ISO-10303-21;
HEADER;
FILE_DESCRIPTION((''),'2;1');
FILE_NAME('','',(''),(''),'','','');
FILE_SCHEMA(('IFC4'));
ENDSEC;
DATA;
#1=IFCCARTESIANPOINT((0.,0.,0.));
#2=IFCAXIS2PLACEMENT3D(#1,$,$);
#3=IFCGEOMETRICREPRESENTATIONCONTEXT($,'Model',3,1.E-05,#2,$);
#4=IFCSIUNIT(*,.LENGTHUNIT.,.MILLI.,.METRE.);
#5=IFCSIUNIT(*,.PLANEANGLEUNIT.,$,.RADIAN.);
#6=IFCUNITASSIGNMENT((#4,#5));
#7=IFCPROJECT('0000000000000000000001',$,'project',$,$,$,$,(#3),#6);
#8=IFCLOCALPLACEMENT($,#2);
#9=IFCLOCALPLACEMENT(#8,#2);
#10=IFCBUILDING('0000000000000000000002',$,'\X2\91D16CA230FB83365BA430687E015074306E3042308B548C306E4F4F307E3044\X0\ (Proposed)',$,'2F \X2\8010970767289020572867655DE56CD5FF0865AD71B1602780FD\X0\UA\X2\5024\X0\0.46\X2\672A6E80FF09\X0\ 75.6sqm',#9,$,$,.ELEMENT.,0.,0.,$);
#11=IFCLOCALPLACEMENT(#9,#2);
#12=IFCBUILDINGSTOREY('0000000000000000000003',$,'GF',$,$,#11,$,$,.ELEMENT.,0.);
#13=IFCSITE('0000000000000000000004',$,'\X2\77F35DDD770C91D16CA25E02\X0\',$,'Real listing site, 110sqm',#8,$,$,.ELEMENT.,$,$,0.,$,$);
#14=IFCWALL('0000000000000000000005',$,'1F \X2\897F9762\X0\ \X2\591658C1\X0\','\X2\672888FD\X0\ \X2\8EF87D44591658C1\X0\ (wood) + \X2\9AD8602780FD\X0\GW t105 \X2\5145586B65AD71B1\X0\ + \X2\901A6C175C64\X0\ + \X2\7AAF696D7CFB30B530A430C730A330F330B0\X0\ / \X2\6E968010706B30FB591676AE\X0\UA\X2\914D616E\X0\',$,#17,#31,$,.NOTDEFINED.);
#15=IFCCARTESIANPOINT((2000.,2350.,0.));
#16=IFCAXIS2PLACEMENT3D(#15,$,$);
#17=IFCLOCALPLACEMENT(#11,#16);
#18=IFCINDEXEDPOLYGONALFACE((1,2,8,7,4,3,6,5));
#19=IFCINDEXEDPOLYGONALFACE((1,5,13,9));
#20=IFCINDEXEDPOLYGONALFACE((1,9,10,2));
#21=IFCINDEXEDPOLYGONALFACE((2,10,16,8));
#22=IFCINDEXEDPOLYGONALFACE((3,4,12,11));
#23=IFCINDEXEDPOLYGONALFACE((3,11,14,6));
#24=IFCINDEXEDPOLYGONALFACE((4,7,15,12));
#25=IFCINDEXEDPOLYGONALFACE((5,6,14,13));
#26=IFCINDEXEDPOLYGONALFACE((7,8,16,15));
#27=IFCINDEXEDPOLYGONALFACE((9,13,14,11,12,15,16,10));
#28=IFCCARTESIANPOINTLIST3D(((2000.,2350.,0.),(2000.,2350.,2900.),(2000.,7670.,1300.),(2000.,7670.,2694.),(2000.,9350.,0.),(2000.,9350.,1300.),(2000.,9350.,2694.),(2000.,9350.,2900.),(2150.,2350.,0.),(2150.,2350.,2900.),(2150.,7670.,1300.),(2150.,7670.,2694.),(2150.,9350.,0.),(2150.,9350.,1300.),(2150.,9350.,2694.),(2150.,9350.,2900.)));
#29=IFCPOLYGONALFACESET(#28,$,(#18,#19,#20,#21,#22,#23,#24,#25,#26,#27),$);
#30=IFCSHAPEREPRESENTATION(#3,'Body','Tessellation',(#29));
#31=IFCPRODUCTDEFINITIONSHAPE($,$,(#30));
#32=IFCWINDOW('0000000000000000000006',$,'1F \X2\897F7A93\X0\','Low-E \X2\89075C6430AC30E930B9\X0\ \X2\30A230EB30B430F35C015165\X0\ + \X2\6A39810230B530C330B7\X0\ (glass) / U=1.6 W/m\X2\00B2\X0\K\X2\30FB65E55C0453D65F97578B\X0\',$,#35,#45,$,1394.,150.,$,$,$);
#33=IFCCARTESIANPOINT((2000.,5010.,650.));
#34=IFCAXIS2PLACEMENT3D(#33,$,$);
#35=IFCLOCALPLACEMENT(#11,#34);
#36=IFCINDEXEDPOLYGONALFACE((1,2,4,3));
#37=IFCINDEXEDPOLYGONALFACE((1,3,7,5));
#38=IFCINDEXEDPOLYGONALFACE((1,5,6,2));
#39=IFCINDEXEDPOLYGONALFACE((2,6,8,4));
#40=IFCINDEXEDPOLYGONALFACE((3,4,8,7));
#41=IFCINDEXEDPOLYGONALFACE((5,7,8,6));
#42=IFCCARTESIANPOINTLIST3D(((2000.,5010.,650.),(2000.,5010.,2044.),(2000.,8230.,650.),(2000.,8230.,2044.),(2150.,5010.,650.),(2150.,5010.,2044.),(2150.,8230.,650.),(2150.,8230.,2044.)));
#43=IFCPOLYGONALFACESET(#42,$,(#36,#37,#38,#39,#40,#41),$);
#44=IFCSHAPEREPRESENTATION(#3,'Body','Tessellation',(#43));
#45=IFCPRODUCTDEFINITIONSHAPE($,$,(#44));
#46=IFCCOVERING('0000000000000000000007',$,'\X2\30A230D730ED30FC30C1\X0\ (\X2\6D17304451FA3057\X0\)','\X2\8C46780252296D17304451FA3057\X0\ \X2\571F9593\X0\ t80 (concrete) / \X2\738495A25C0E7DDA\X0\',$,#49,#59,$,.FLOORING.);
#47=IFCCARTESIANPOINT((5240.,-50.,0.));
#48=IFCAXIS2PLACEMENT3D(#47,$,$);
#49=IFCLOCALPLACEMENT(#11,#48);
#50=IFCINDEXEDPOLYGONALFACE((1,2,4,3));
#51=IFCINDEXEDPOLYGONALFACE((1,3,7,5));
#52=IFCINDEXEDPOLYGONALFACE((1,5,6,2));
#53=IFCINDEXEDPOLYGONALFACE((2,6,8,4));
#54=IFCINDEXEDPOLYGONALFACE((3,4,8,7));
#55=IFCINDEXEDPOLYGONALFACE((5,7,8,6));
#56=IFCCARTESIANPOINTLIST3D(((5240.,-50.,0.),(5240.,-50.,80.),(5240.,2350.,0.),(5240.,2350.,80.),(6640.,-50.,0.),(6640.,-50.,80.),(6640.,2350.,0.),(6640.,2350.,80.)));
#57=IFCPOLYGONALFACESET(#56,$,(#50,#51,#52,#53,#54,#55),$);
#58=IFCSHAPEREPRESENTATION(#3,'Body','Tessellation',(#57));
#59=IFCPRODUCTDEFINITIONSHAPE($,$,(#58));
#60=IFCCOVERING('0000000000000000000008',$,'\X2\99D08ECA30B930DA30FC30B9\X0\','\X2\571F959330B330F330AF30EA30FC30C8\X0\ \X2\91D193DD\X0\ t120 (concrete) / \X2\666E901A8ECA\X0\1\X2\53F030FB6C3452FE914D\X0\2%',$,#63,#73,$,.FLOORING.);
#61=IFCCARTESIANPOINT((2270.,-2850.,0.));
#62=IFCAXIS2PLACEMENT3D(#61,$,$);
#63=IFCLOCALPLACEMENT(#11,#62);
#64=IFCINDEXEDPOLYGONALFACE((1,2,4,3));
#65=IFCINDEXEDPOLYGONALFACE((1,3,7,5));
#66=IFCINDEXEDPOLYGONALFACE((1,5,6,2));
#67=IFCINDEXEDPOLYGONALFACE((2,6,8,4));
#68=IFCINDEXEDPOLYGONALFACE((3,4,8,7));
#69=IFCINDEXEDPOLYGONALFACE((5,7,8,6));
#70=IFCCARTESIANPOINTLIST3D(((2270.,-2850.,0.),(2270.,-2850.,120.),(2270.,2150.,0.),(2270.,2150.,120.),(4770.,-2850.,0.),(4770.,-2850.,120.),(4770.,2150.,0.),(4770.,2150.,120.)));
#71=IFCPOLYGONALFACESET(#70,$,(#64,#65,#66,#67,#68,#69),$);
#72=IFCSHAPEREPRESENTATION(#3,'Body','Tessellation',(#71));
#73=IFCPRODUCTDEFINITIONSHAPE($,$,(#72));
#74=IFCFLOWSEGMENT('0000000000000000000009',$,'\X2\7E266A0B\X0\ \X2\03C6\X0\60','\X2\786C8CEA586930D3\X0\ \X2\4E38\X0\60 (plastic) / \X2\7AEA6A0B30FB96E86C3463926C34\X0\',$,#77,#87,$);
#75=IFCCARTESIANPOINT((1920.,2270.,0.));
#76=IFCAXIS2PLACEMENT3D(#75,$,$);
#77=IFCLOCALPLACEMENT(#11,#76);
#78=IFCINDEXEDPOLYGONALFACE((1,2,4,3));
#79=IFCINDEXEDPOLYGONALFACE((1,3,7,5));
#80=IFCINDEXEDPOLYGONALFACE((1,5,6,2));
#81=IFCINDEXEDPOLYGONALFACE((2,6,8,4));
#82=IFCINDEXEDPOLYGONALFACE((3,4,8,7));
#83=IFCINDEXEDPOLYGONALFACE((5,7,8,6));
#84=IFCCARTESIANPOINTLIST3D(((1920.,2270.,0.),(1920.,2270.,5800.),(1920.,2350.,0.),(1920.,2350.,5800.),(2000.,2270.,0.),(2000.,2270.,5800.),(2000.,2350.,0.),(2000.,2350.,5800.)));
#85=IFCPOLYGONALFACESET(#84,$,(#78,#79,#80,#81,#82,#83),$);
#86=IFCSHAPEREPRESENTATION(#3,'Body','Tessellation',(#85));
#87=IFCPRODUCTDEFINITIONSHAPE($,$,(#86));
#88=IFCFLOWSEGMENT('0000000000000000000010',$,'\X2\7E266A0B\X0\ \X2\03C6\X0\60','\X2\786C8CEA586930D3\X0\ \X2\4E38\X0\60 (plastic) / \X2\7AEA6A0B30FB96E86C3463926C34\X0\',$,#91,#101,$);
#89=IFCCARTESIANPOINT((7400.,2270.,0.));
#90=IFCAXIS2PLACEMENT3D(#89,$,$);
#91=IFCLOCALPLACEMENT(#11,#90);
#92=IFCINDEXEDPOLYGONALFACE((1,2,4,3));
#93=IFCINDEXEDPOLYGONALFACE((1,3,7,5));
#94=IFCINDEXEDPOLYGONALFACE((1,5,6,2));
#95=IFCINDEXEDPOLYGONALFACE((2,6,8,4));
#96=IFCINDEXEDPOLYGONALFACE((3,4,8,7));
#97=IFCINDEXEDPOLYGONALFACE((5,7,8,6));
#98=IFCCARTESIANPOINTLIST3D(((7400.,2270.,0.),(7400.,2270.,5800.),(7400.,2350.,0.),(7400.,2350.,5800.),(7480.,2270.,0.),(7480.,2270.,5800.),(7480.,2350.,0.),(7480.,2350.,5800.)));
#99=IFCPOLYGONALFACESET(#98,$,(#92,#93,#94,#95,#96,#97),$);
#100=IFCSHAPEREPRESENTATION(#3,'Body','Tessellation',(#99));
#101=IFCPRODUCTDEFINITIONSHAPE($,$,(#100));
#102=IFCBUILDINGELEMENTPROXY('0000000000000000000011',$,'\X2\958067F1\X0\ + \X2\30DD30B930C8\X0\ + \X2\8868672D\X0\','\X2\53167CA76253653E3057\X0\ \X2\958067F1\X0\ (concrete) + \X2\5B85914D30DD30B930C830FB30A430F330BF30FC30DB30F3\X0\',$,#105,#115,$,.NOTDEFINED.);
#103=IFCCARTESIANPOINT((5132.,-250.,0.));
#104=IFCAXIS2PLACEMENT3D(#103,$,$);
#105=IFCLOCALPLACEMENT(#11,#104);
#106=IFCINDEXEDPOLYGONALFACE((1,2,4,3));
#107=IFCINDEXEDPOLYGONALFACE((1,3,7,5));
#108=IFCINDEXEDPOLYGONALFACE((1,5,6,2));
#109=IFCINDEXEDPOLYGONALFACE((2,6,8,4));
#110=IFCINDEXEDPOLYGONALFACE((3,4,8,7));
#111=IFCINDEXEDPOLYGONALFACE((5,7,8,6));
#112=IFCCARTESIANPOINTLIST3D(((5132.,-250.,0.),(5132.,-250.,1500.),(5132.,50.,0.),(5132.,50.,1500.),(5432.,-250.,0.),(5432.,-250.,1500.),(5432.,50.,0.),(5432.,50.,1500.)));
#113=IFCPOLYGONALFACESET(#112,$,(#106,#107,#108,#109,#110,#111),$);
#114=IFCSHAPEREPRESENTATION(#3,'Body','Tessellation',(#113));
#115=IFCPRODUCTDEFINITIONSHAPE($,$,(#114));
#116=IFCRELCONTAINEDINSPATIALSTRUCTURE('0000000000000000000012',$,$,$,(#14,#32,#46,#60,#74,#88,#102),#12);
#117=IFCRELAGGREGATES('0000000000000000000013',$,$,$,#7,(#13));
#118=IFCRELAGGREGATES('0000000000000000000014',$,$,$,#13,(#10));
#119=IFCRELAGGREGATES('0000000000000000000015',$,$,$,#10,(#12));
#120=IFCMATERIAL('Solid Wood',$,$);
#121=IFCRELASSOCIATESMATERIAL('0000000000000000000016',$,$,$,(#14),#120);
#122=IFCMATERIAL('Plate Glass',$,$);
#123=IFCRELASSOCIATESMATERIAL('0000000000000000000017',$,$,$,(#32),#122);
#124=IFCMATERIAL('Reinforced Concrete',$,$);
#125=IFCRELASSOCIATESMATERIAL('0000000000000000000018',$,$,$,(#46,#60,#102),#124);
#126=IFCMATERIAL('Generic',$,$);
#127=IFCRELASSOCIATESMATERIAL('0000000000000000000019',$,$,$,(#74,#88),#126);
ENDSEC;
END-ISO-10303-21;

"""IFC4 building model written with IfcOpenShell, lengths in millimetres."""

from ifc_helpers import new_model, si_unit, frame, frame_2d, origin, place, context, project, spatial, rectangle, extrude, material, element, fill, save


model = new_model("IFC4")

# Units and contexts
model_context = context("Model", 3, precision=1e-05, world=origin())
ifc_project = project(units=[si_unit("LENGTHUNIT", "METRE", prefix="MILLI"), si_unit("PLANEANGLEUNIT", "RADIAN")], contexts=[model_context])

# Site, building, storey
site_placement = place(None, origin())
site = spatial("IfcSite", under=ifc_project, at=site_placement, Name="石川県金沢市", ObjectType="Real listing site, 110sqm", CompositionType="ELEMENT", RefElevation=0.0)
building_placement = place(site_placement, origin())
building = spatial("IfcBuilding", under=site, at=building_placement, Name="金沢・茶室と縁側のある和の住まい (Proposed)", ObjectType="2F 耐震木造在来工法（断熱性能UA値0.46未満） 75.6sqm", CompositionType="ELEMENT", ElevationOfRefHeight=0.0, ElevationOfTerrain=0.0)
storey_placement = place(building_placement, origin())
storey = spatial("IfcBuildingStorey", under=building, at=storey_placement, Name="GF", CompositionType="ELEMENT", Elevation=0.0)

# Shared definitions
ifc_material_1 = material(Name="Solid Wood")

# Shared definitions
ifc_material_2 = material(Name="Reinforced Concrete")

# Shared definitions
ifc_material_3 = material(Name="Plate Glass")

# Wall, opening, window
wall_1_placement = place(storey_placement, frame((2000.0, 2350.0, 0.0)))
wall_1 = element("IfcWall", 1, at=wall_1_placement, inside=storey, material=ifc_material_1, Name="1F 西面 外壁", Description="木製 軸組外壁 (wood) + 高性能GW t105 充填断熱 + 通気層 + 窯業系サイディング / 準耐火・外皮UA配慮", PredefinedType="NOTDEFINED", context=model_context, shape_type="SweptSolid", body=[
    extrude(rectangle(XDim=150.0, YDim=7000.0, at=frame_2d((75.0, 3500.0))), frame((2000.0, 2350.0, 0.0)), (0.0, 0.0, 1.0), 2900.0),
])
opening_1_placement = place(storey_placement, frame((2000.0, 5010.0, 650.0)))
opening_1 = element("IfcOpeningElement", 2, at=opening_1_placement, cuts=wall_1, PredefinedType="NOTDEFINED", context=model_context, shape_type="SweptSolid", body=[
    extrude(rectangle(XDim=150.0, YDim=3220.0, at=frame_2d((75.0, 1610.0))), frame((2000.0, 5010.0, 650.0)), (0.0, 0.0, 1.0), 1394.0),
])
window_1_placement = place(storey_placement, frame((2000.0, 5010.0, 650.0)))
window_1 = element("IfcWindow", 3, at=window_1_placement, inside=storey, material=ifc_material_3, Name="1F 西窓", Description="Low-E 複層ガラス アルゴン封入 + 樹脂サッシ (glass) / U=1.6 W/m²K・日射取得型", OverallHeight=1394.0, OverallWidth=150.0, context=model_context, shape_type="SweptSolid", body=[
    extrude(rectangle(XDim=150.0, YDim=3220.0, at=frame_2d((75.0, 1610.0))), frame((2000.0, 5010.0, 650.0)), (0.0, 0.0, 1.0), 1394.0),
])
fill(opening_1, window_1)

# Coverings
covering_1_placement = place(storey_placement, frame((5240.0, -50.0, 0.0)))
element("IfcCovering", 4, at=covering_1_placement, inside=storey, material=ifc_material_2, Name="アプローチ (洗い出し)", Description="豆砂利洗い出し 土間 t80 (concrete) / 玄関導線", PredefinedType="FLOORING", context=model_context, shape_type="SweptSolid", body=[
    extrude(rectangle(XDim=1400.0, YDim=2400.0, at=frame_2d((700.0, 1200.0))), frame((5240.0, -50.0, 0.0)), (0.0, 0.0, 1.0), 80.0),
])
covering_2_placement = place(storey_placement, frame((2270.0, -2850.0, 0.0)))
element("IfcCovering", 5, at=covering_2_placement, inside=storey, material=ifc_material_2, Name="駐車スペース", Description="土間コンクリート 金鏝 t120 (concrete) / 普通車1台・水勾配2%", PredefinedType="FLOORING", context=model_context, shape_type="SweptSolid", body=[
    extrude(rectangle(XDim=2500.0, YDim=5000.0, at=frame_2d((1250.0, 2500.0))), frame((2270.0, -2850.0, 0.0)), (0.0, 0.0, 1.0), 120.0),
])

# Flow segments
ifc_material_4 = material(Name="Generic")
flow_segment_1_placement = place(storey_placement, frame((1920.0, 2270.0, 0.0)))
element("IfcFlowSegment", 6, at=flow_segment_1_placement, inside=storey, material=ifc_material_4, Name="縦樋 φ60", Description="硬質塩ビ 丸60 (plastic) / 竪樋・雨水排水", context=model_context, shape_type="SweptSolid", body=[
    extrude(rectangle(XDim=80.0, YDim=80.0, at=frame_2d((40.0, 40.0))), frame((1920.0, 2270.0, 0.0)), (0.0, 0.0, 1.0), 5800.0),
])
flow_segment_2_placement = place(storey_placement, frame((7400.0, 2270.0, 0.0)))
element("IfcFlowSegment", 7, at=flow_segment_2_placement, inside=storey, material=ifc_material_4, Name="縦樋 φ60", Description="硬質塩ビ 丸60 (plastic) / 竪樋・雨水排水", context=model_context, shape_type="SweptSolid", body=[
    extrude(rectangle(XDim=80.0, YDim=80.0, at=frame_2d((40.0, 40.0))), frame((7400.0, 2270.0, 0.0)), (0.0, 0.0, 1.0), 5800.0),
])

# Building element proxy
proxy_placement = place(storey_placement, frame((5132.0, -250.0, 0.0)))
element("IfcBuildingElementProxy", 8, at=proxy_placement, inside=storey, material=ifc_material_2, Name="門柱 + ポスト + 表札", Description="化粧打放し 門柱 (concrete) + 宅配ポスト・インターホン", PredefinedType="NOTDEFINED", context=model_context, shape_type="SweptSolid", body=[
    extrude(rectangle(XDim=300.0, YDim=300.0, at=frame_2d((150.0, 150.0))), frame((5132.0, -250.0, 0.0)), (0.0, 0.0, 1.0), 1500.0),
])

save(model, "model.ifc")
